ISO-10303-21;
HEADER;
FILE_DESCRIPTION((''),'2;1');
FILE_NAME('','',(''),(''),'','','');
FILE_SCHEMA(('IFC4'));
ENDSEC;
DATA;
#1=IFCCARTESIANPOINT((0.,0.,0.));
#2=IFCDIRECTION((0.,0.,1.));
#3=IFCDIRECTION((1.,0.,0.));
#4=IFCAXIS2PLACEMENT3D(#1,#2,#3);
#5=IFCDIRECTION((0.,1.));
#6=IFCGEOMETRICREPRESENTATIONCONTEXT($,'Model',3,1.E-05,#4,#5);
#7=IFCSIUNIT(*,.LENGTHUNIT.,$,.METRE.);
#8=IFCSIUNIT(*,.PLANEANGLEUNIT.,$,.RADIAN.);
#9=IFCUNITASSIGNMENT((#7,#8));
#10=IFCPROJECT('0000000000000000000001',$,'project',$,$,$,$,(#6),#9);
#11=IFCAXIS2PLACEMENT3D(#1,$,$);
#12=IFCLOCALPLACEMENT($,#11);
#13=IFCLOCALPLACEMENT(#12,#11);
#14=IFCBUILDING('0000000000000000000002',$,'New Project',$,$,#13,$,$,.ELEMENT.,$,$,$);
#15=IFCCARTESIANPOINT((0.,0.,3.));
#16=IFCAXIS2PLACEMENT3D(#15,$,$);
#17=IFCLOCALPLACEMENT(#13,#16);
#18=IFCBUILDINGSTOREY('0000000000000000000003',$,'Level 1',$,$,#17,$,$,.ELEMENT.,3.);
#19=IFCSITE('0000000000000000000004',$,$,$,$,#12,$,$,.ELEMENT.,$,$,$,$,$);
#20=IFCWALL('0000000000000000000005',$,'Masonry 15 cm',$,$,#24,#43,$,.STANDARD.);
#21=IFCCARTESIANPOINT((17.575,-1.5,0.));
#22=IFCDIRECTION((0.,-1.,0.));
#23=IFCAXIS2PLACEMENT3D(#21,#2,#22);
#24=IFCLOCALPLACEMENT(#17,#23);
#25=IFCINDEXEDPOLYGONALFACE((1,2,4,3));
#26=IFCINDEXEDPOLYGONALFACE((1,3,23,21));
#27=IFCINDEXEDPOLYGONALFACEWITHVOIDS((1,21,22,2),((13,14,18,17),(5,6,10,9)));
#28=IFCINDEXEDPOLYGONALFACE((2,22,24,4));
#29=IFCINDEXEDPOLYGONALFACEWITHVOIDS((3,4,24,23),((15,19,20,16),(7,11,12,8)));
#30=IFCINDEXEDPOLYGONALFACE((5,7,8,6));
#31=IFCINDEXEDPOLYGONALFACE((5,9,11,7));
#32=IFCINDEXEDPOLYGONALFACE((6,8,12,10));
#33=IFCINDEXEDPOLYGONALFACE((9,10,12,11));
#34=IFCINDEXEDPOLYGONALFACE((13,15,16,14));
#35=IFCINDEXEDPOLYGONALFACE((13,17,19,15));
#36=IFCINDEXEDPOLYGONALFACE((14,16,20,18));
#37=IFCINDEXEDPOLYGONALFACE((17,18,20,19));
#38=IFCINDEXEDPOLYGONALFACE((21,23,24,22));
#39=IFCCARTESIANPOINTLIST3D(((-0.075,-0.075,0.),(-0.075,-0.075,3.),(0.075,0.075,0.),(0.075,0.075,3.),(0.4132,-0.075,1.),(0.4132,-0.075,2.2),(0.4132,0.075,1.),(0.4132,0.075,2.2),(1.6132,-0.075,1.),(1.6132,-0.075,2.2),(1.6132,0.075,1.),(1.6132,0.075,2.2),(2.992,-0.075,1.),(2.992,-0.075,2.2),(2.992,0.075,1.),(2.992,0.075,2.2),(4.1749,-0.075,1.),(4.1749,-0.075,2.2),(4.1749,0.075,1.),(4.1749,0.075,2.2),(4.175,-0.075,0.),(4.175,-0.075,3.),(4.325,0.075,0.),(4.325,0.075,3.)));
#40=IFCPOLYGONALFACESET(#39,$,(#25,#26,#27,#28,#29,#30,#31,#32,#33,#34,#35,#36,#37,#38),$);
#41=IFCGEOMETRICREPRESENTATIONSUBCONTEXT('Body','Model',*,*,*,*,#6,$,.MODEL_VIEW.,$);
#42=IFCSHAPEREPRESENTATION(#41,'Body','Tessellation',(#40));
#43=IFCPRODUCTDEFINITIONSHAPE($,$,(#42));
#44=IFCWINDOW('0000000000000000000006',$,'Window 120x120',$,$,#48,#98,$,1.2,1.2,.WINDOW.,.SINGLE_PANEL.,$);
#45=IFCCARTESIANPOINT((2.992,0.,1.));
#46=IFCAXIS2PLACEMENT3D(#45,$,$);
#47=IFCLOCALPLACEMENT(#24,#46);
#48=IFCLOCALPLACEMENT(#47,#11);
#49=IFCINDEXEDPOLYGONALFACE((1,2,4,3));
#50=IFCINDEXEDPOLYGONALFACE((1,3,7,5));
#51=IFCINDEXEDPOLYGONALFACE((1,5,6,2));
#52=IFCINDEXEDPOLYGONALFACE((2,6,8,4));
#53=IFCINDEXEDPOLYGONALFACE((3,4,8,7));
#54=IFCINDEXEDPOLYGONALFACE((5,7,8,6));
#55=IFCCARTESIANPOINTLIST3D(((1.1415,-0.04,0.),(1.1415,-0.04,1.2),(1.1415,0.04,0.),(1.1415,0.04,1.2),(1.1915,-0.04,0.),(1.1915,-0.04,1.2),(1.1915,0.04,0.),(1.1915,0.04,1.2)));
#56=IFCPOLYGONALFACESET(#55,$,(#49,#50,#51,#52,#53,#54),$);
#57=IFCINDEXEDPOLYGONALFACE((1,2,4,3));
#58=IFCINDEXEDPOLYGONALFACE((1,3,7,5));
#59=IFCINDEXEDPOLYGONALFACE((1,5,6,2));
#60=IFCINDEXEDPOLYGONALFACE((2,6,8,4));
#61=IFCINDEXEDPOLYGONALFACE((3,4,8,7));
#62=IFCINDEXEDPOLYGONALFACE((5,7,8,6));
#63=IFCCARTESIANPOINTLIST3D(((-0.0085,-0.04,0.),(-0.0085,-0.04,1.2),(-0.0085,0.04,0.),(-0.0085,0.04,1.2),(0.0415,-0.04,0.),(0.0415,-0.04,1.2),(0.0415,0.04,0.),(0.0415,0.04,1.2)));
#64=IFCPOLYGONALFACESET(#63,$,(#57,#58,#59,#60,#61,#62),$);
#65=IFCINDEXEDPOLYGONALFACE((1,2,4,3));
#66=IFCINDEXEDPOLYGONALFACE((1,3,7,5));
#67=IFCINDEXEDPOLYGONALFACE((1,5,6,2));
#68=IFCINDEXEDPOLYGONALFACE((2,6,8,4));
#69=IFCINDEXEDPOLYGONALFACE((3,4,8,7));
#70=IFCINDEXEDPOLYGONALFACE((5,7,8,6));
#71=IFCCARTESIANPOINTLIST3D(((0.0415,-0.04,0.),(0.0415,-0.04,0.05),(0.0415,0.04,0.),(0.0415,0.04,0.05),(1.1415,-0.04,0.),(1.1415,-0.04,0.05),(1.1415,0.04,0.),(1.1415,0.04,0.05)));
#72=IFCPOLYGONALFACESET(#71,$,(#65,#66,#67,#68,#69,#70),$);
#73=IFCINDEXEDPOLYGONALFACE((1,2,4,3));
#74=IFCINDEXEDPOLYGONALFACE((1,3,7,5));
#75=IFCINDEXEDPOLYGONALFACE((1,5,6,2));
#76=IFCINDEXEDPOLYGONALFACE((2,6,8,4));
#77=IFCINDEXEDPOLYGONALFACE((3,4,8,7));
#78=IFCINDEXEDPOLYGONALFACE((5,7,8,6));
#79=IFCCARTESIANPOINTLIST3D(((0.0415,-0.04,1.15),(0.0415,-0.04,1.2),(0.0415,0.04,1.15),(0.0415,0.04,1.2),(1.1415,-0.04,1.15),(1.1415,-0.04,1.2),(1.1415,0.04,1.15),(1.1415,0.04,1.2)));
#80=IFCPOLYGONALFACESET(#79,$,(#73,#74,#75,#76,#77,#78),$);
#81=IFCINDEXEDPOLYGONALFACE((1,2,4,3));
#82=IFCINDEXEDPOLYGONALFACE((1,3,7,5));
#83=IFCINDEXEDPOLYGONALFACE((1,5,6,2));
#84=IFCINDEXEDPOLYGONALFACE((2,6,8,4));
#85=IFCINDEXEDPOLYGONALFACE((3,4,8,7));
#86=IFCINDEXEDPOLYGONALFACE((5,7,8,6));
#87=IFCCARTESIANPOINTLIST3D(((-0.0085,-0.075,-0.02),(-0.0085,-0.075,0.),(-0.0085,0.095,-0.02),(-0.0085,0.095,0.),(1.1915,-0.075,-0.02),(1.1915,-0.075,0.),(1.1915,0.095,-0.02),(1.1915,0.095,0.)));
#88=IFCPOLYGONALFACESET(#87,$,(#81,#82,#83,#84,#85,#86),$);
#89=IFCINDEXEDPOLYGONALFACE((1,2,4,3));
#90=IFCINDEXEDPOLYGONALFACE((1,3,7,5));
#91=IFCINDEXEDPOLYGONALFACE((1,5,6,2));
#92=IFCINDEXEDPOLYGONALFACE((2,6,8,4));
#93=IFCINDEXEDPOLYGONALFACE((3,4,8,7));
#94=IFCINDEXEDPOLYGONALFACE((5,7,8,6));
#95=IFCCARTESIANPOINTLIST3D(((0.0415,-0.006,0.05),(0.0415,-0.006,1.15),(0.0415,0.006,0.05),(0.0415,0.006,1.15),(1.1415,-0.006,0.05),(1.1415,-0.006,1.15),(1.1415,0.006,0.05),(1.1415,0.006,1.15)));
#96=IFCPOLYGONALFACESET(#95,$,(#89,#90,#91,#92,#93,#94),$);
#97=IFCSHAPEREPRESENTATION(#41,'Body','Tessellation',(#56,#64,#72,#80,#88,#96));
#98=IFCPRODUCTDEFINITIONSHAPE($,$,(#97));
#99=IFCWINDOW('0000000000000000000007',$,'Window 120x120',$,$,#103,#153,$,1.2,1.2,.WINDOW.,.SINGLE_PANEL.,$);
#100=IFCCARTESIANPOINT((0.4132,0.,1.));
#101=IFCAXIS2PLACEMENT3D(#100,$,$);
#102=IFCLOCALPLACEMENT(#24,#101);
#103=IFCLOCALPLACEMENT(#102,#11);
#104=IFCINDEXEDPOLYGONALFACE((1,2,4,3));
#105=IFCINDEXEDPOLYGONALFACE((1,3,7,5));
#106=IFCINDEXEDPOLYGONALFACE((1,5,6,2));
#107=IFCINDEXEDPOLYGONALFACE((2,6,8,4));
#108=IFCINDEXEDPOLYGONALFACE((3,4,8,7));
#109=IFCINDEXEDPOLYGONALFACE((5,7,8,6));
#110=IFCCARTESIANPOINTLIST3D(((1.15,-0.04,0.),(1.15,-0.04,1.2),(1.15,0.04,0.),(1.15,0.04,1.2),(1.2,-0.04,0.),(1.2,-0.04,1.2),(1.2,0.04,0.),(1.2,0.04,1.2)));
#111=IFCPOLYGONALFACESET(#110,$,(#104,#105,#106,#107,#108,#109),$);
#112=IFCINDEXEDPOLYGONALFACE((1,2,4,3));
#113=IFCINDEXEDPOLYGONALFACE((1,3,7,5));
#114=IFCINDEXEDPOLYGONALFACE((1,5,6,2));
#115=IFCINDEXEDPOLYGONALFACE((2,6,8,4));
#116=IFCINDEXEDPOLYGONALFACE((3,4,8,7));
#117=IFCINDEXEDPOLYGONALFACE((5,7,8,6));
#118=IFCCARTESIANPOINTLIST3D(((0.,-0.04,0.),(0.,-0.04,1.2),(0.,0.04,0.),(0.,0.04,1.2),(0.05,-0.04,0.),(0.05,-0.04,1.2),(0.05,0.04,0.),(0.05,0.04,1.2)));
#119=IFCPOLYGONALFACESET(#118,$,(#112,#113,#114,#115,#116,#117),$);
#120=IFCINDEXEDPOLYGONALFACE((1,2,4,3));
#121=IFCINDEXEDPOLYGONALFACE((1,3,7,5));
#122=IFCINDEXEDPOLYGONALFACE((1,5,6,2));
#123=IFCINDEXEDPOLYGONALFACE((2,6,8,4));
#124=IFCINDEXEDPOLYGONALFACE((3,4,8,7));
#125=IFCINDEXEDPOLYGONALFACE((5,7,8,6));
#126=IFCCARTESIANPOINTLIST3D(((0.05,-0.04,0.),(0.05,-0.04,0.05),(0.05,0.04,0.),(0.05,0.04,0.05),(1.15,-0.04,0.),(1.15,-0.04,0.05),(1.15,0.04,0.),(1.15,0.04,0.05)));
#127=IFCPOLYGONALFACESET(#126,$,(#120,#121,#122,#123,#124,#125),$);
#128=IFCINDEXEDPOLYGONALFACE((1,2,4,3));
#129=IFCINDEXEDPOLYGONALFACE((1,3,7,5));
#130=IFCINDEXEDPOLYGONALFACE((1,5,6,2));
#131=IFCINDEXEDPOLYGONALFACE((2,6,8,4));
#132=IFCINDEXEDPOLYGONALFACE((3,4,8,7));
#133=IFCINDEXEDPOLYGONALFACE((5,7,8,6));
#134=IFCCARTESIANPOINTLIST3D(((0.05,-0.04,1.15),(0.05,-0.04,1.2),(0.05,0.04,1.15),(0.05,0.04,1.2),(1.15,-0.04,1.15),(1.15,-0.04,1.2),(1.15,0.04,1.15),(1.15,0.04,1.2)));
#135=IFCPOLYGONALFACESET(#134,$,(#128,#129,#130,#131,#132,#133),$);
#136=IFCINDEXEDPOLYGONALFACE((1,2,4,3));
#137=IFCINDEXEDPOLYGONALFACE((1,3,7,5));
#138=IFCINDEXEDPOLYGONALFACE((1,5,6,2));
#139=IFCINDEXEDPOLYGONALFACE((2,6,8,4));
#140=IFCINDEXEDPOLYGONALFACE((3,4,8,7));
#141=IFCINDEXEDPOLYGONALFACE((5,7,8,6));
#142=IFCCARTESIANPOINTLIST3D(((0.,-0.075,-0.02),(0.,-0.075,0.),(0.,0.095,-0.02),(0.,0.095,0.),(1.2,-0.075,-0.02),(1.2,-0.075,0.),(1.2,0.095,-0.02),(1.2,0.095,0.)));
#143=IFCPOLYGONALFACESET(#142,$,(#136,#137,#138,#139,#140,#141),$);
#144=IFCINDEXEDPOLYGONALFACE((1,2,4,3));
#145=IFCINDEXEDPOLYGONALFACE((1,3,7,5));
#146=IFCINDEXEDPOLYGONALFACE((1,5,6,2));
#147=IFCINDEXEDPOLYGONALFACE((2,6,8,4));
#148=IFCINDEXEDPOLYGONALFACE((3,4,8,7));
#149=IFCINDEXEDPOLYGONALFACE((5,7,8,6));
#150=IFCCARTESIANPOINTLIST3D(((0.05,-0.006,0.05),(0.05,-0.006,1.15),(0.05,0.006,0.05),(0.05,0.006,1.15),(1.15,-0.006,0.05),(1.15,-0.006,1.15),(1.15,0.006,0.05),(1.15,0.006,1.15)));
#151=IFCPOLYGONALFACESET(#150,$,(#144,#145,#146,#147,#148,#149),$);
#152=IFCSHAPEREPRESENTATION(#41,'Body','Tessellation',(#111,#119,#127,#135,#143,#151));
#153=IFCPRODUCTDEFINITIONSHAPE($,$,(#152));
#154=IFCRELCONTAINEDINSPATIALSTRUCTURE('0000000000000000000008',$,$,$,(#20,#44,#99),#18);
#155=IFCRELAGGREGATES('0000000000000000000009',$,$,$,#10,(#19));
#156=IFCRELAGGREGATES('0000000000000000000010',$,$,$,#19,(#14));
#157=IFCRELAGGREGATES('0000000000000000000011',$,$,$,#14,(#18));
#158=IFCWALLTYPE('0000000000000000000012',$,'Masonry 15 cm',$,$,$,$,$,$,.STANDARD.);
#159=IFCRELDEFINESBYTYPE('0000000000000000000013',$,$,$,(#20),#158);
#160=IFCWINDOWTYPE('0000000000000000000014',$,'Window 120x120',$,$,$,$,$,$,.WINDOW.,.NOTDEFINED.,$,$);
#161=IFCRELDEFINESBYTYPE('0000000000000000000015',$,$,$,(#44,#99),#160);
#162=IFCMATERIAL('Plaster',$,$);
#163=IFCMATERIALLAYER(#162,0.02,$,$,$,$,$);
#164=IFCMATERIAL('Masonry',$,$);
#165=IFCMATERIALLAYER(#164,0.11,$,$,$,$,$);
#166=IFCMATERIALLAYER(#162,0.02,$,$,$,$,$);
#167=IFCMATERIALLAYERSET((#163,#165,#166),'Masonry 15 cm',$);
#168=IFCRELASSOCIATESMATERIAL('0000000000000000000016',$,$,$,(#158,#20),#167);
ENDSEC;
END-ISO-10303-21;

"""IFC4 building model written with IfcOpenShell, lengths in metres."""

from ifc_helpers import new_model, si_unit, direction, frame, frame_2d, origin, origin_with_axes, place, context, subcontext, project, spatial, polyline, rectangle, outline, extrude, material, layer, layer_set, layer_usage, type_object, element, fill, save


model = new_model("IFC4")

# Units and contexts
model_context = context("Model", 3, precision=1e-05, world=origin_with_axes(), true_north=direction((0.0, 1.0)))
body_context = subcontext(model_context, "Body", "Model", "MODEL_VIEW")
ifc_project = project(units=[si_unit("LENGTHUNIT", "METRE"), si_unit("PLANEANGLEUNIT", "RADIAN")], contexts=[model_context])

# Site, building, storey
site_placement = place(None, origin())
site = spatial("IfcSite", under=ifc_project, at=site_placement, CompositionType="ELEMENT")
building_placement = place(site_placement, origin())
building = spatial("IfcBuilding", under=site, at=building_placement, Name="New Project", CompositionType="ELEMENT")
storey_placement = place(building_placement, frame((0.0, 0.0, 3.0)))
storey = spatial("IfcBuildingStorey", under=building, at=storey_placement, Name="Level 1", CompositionType="ELEMENT", Elevation=3.0)

# Shared definitions
ifc_material_1 = material(Name="Plaster")
ifc_layer_1 = layer(ifc_material_1, 0.02)
ifc_material_2 = material(Name="Masonry")
ifc_layer_2 = layer(ifc_material_2, 0.11)
ifc_layer_3 = layer(ifc_material_1, 0.02)
ifc_layer_set_1 = layer_set([ifc_layer_1, ifc_layer_2, ifc_layer_3], Name="Masonry 15 cm")
ifc_layer_usage_1 = layer_usage(ifc_layer_set_1, "AXIS2", "NEGATIVE", 0.075)
wall_type_1 = type_object("IfcWallType", Name="Masonry 15 cm", PredefinedType="STANDARD", material=ifc_layer_set_1)

# Shared definitions
window_type_1 = type_object("IfcWindowType", Name="Window 120x120", PartitioningType="NOTDEFINED", PredefinedType="WINDOW")

# Wall, openings, windows
wall_1_placement = place(storey_placement, frame((17.575, -1.5, 0.0), z_axis=(0.0, 0.0, 1.0), x_axis=(0.0, -1.0, 0.0)))
wall_1 = element("IfcWall", 1, at=wall_1_placement, inside=storey, type_object=wall_type_1, material=ifc_layer_usage_1, Name="Masonry 15 cm", PredefinedType="STANDARD", context=body_context, shape_type="SweptSolid", body=[
    extrude(outline(polyline([(-0.075, -0.075), (4.175, -0.075), (4.325, 0.075), (0.075, 0.075), (-0.075, -0.075)])), origin(), (0.0, 0.0, 1.0), 3.0),
])
opening_1_placement = place(wall_1_placement, frame((2.992, 0.0, 1.0)))
opening_1 = element("IfcOpeningElement", 2, at=opening_1_placement, cuts=wall_1, PredefinedType="OPENING", context=body_context, shape_type="SweptSolid", body=[
    extrude(rectangle(XDim=1.1829, YDim=0.25, at=frame_2d((0.5915, 0.0))), origin(), (0.0, 0.0, 1.0), 1.2),
])
opening_2_placement = place(wall_1_placement, frame((0.4132, 0.0, 1.0)))
opening_2 = element("IfcOpeningElement", 3, at=opening_2_placement, cuts=wall_1, PredefinedType="OPENING", context=body_context, shape_type="SweptSolid", body=[
    extrude(rectangle(XDim=1.2, YDim=0.25, at=frame_2d((0.6, 0.0))), origin(), (0.0, 0.0, 1.0), 1.2),
])
window_1_placement = place(opening_1_placement, origin())
window_1 = element("IfcWindow", 4, at=window_1_placement, inside=storey, type_object=window_type_1, Name="Window 120x120", OverallHeight=1.2, OverallWidth=1.2, PartitioningType="SINGLE_PANEL", PredefinedType="WINDOW", context=body_context, shape_type="SweptSolid", body=[
    extrude(outline(polyline([(1.1915, 0.04), (1.1415, 0.04), (1.1415, -0.04), (1.1915, -0.04), (1.1915, 0.04)])), origin(), (0.0, 0.0, 1.0), 1.2),
    extrude(outline(polyline([(0.0415, 0.04), (-0.0085, 0.04), (-0.0085, -0.04), (0.0415, -0.04), (0.0415, 0.04)])), origin(), (0.0, 0.0, 1.0), 1.2),
    extrude(outline(polyline([(1.1415, 0.04), (0.0415, 0.04), (0.0415, -0.04), (1.1415, -0.04), (1.1415, 0.04)])), origin(), (0.0, 0.0, 1.0), 0.05),
    extrude(outline(polyline([(1.1415, 0.04), (0.0415, 0.04), (0.0415, -0.04), (1.1415, -0.04), (1.1415, 0.04)])), frame((0.0, 0.0, 1.15)), (0.0, 0.0, 1.0), 0.05),
    extrude(outline(polyline([(1.1915, 0.095), (-0.0085, 0.095), (-0.0085, -0.075), (1.1915, -0.075), (1.1915, 0.095)])), frame((0.0, 0.0, -0.02)), (0.0, 0.0, 1.0), 0.02),
    extrude(outline(polyline([(1.1415, 0.006), (0.0415, 0.006), (0.0415, -0.006), (1.1415, -0.006), (1.1415, 0.006)])), frame((0.0, 0.0, 0.05)), (0.0, 0.0, 1.0), 1.1),
])
fill(opening_1, window_1)
window_2_placement = place(opening_2_placement, origin())
window_2 = element("IfcWindow", 5, at=window_2_placement, inside=storey, type_object=window_type_1, Name="Window 120x120", OverallHeight=1.2, OverallWidth=1.2, PartitioningType="SINGLE_PANEL", PredefinedType="WINDOW", context=body_context, shape_type="SweptSolid", body=[
    extrude(outline(polyline([(1.2, 0.04), (1.15, 0.04), (1.15, -0.04), (1.2, -0.04), (1.2, 0.04)])), origin(), (0.0, 0.0, 1.0), 1.2),
    extrude(outline(polyline([(0.05, 0.04), (0.0, 0.04), (0.0, -0.04), (0.05, -0.04), (0.05, 0.04)])), origin(), (0.0, 0.0, 1.0), 1.2),
    extrude(outline(polyline([(1.15, 0.04), (0.05, 0.04), (0.05, -0.04), (1.15, -0.04), (1.15, 0.04)])), origin(), (0.0, 0.0, 1.0), 0.05),
    extrude(outline(polyline([(1.15, 0.04), (0.05, 0.04), (0.05, -0.04), (1.15, -0.04), (1.15, 0.04)])), frame((0.0, 0.0, 1.15)), (0.0, 0.0, 1.0), 0.05),
    extrude(outline(polyline([(1.2, 0.095), (0.0, 0.095), (0.0, -0.075), (1.2, -0.075), (1.2, 0.095)])), frame((0.0, 0.0, -0.02)), (0.0, 0.0, 1.0), 0.02),
    extrude(outline(polyline([(1.15, 0.006), (0.05, 0.006), (0.05, -0.006), (1.15, -0.006), (1.15, 0.006)])), frame((0.0, 0.0, 0.05)), (0.0, 0.0, 1.0), 1.1),
])
fill(opening_2, window_2)

save(model, "model.ifc")
